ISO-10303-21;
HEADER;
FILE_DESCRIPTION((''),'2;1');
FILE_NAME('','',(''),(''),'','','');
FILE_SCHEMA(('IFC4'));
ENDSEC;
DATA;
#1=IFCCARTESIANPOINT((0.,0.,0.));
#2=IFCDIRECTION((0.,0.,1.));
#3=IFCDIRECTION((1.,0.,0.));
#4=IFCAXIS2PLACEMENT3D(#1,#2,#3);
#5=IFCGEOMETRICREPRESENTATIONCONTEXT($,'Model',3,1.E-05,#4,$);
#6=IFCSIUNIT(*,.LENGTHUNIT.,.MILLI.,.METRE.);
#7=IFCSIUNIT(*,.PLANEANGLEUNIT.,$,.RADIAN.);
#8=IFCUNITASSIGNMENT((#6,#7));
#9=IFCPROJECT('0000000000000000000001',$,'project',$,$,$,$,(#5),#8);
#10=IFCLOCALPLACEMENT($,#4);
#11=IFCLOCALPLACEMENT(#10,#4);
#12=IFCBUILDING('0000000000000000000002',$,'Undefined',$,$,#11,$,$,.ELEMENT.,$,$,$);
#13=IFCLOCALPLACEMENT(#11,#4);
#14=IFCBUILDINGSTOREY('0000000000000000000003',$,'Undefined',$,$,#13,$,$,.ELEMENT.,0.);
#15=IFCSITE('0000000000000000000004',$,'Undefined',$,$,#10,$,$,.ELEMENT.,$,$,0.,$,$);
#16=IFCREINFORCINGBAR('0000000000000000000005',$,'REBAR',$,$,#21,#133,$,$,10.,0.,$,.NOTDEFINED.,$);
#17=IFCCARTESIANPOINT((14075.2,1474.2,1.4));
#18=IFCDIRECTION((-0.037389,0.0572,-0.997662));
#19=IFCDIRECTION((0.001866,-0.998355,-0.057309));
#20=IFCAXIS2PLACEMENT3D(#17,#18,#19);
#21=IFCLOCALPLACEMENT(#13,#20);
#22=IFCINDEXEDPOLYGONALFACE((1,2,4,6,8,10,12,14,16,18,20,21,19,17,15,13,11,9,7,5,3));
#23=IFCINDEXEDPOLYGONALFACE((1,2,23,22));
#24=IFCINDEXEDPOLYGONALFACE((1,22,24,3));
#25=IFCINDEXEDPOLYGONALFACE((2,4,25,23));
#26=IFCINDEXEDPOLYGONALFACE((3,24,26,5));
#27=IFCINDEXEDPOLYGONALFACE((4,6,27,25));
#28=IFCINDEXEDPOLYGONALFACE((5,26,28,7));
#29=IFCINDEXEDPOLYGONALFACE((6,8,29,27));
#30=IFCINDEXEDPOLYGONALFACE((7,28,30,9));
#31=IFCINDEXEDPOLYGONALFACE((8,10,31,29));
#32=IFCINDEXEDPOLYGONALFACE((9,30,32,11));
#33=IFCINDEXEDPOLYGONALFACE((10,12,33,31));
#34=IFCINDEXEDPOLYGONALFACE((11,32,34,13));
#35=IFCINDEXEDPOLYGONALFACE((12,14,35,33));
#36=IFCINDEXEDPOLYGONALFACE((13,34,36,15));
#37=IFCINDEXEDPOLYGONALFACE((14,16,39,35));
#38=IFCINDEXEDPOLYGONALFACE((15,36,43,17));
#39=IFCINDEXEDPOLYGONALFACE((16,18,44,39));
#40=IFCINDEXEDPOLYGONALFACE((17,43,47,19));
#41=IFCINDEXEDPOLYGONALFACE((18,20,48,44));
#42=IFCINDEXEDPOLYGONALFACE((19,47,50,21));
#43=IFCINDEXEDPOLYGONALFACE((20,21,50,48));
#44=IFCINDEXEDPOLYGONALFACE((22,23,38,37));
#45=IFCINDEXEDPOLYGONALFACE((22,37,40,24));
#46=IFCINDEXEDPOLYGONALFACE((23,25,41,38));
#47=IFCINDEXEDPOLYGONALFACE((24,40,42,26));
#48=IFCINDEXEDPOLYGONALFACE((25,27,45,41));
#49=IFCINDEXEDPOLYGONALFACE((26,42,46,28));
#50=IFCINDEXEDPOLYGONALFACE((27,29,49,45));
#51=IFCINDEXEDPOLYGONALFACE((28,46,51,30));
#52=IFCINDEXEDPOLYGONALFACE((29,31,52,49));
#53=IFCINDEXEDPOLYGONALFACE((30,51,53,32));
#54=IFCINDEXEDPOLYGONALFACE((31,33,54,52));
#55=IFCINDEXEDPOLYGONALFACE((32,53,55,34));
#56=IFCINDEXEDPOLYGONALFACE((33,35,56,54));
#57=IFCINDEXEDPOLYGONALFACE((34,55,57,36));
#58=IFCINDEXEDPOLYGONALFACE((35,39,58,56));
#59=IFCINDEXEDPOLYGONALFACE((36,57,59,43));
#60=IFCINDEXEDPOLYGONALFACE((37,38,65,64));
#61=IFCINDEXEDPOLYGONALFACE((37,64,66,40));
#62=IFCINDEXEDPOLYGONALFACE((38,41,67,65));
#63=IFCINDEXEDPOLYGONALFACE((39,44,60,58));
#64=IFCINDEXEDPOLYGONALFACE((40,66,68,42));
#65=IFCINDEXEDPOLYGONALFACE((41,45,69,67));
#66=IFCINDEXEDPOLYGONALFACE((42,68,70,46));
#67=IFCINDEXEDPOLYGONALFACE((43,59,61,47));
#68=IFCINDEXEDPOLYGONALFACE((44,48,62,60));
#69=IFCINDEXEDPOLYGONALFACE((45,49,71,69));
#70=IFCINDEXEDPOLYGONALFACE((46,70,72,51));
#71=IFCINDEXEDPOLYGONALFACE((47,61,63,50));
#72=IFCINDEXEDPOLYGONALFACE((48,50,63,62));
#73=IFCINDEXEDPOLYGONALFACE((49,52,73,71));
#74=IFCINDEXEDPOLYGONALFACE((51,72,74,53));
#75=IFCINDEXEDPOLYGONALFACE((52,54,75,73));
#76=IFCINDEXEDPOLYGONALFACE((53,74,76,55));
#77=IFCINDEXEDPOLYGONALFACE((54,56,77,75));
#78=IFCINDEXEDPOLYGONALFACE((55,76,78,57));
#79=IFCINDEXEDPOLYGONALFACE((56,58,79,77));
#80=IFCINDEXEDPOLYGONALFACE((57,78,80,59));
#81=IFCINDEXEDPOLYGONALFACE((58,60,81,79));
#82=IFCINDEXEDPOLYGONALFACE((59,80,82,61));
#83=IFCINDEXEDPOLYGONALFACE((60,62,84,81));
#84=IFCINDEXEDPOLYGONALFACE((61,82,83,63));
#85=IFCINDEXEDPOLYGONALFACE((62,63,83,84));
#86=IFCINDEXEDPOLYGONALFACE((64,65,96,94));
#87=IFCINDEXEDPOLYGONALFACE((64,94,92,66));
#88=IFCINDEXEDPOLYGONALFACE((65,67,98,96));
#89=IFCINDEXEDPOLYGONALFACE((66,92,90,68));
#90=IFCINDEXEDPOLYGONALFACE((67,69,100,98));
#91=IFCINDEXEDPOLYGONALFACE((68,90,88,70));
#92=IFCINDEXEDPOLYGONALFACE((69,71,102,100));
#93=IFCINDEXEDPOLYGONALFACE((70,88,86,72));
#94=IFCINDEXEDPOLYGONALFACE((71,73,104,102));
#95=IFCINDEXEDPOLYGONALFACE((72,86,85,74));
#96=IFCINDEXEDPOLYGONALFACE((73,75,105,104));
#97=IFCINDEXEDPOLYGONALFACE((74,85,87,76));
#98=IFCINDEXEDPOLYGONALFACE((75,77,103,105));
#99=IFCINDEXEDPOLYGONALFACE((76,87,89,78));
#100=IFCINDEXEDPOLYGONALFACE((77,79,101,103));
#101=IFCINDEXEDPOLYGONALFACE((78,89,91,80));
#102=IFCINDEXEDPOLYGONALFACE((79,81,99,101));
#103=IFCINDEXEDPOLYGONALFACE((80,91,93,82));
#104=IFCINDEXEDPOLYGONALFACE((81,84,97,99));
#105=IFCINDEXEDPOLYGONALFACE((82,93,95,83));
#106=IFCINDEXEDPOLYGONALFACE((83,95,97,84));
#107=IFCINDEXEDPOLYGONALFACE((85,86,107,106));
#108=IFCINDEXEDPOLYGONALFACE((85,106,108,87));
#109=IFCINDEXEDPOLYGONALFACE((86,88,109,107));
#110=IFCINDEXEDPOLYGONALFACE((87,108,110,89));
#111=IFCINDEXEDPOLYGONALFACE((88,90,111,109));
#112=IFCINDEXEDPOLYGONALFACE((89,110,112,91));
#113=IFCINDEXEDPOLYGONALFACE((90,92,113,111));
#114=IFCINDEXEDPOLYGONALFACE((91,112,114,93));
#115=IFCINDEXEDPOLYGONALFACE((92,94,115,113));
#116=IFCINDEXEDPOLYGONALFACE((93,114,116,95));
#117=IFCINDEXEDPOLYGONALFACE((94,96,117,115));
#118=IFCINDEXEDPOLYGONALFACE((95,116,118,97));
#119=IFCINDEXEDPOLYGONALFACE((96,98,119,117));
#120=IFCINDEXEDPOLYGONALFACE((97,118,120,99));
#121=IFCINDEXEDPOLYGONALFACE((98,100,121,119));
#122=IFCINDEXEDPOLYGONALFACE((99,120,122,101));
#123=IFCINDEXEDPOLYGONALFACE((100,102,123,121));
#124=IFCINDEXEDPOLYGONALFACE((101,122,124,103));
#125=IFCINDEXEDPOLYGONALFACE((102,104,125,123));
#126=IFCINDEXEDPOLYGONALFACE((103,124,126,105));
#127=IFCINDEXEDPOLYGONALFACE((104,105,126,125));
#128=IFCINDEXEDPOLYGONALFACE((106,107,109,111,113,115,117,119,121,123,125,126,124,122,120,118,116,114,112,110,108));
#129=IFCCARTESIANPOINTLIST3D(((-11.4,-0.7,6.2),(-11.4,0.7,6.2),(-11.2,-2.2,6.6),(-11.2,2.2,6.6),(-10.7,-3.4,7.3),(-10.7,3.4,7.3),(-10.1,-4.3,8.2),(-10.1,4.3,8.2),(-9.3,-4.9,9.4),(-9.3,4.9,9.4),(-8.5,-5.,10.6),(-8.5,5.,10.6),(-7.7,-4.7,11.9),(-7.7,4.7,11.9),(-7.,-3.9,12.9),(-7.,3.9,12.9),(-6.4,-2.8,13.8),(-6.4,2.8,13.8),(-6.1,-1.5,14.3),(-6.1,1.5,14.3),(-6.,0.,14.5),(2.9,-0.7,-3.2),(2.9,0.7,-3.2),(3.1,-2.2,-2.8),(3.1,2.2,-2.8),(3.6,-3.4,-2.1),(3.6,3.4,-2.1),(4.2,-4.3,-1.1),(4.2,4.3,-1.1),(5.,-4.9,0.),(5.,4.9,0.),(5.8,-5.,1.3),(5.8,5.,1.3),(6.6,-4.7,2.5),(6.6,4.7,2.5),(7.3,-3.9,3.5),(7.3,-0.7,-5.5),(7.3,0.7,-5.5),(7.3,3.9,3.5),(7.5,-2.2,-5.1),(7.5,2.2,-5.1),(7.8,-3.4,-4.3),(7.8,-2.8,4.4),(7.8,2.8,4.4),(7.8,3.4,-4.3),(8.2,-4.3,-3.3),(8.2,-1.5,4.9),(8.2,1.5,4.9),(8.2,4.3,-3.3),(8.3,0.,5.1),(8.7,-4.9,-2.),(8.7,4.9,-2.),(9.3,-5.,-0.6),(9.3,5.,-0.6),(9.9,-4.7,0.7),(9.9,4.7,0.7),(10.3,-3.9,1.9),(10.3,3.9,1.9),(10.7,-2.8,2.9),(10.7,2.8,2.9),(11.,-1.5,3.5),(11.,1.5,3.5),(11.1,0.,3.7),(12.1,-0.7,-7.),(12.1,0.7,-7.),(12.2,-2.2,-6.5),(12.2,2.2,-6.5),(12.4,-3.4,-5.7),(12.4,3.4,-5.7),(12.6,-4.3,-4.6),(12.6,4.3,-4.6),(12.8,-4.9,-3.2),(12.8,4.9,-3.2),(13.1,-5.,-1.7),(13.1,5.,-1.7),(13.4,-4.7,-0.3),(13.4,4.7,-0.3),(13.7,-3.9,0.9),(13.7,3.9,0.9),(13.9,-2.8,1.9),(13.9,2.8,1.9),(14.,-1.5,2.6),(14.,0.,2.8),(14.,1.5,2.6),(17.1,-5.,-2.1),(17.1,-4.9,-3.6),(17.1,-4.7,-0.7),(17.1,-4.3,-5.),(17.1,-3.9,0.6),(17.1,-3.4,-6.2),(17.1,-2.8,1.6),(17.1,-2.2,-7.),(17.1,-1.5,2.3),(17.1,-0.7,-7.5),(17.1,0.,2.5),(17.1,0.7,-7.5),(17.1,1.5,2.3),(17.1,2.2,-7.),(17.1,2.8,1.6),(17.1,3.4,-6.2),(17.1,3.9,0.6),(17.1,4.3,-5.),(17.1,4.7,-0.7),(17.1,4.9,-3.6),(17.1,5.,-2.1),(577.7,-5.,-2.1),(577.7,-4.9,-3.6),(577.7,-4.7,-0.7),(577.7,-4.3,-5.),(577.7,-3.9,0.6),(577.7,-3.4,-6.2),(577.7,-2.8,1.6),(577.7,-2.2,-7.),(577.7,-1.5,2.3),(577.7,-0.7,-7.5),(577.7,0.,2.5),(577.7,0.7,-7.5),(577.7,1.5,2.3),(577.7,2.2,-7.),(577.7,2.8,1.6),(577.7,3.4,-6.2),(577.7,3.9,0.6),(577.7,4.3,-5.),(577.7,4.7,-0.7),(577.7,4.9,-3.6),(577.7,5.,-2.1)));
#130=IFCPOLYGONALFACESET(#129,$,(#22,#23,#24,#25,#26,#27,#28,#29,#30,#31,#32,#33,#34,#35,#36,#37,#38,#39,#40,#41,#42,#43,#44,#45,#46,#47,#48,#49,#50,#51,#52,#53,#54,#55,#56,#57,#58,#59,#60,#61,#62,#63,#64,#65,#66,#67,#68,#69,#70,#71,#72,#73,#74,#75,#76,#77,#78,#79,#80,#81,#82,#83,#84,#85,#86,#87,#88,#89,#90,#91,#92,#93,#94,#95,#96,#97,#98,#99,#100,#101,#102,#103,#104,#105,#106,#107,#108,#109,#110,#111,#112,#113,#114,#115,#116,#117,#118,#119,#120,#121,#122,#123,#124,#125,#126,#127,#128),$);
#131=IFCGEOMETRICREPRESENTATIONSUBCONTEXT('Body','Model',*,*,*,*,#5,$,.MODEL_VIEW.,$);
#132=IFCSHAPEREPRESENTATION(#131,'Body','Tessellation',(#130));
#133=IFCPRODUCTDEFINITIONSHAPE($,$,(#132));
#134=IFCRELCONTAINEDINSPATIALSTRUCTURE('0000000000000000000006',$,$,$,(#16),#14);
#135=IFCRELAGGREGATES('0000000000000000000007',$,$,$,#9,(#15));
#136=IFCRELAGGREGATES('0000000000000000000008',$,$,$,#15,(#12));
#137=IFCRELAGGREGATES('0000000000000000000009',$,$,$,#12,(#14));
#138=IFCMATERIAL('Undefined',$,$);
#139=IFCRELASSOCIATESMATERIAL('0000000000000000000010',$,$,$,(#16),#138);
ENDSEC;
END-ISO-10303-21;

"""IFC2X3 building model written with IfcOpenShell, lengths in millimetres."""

from ifc_helpers import new_model, entity, si_unit, frame, origin_with_axes, place, context, subcontext, project, spatial, source, transform, mapped, material, element, save


model = new_model("IFC2X3")

# Units and contexts
model_context = context("Model", 3, precision=1e-05, world=origin_with_axes())
body_context = subcontext(model_context, "Body", "Model", "MODEL_VIEW")
ifc_project = project(units=[si_unit("LENGTHUNIT", "METRE", prefix="MILLI"), si_unit("PLANEANGLEUNIT", "RADIAN")], contexts=[model_context])

# Site, building, storey
site_placement = place(None, origin_with_axes())
site = spatial("IfcSite", under=ifc_project, at=site_placement, Name="Undefined", CompositionType="ELEMENT", RefElevation=0.0)
building_placement = place(site_placement, origin_with_axes())
building = spatial("IfcBuilding", under=site, at=building_placement, Name="Undefined", CompositionType="ELEMENT")
storey_placement = place(building_placement, origin_with_axes())
storey = spatial("IfcBuildingStorey", under=building, at=storey_placement, Name="Undefined", CompositionType="ELEMENT", Elevation=0.0)

# Reinforcing bar
ifc_material_1 = material(Name="Undefined")
shared_shape_1 = source(origin_with_axes(), body_context, "Body", "AdvancedSweptSolid", [
    entity("IfcSweptDiskSolid", entity("IfcCompositeCurve", [entity("IfcCompositeCurveSegment", "CONTINUOUS", True, entity("IfcTrimmedCurve", entity("IfcLine", entity("IfcCartesianPoint", [0.0, 0.0, 0.0]), entity("IfcVector", entity("IfcDirection", [0.835483, 0.0, -0.549516]), 1.0)), [entity("IfcParameterValue", 0.0)], [entity("IfcParameterValue", 17.082101)], True, "PARAMETER")), entity("IfcCompositeCurveSegment", "CONTINUOUS", True, entity("IfcTrimmedCurve", entity("IfcCircle", entity("IfcAxis2Placement3D", entity("IfcCartesianPoint", [25.8, 0.0, 8.2]), entity("IfcDirection", [0.0, -1.0, 0.0]), entity("IfcDirection", [-0.549516, 0.0, -0.835483])), 21.0), [entity("IfcParameterValue", 0.0)], [entity("IfcParameterValue", 0.581785)], True, "PARAMETER")), entity("IfcCompositeCurveSegment", "DISCONTINUOUS", True, entity("IfcTrimmedCurve", entity("IfcLine", entity("IfcCartesianPoint", [25.8, 0.0, -12.8]), entity("IfcVector", entity("IfcDirection", [1.0, 0.0, 0.0]), 1.0)), [entity("IfcParameterValue", 0.0)], [entity("IfcParameterValue", 560.593055)], True, "PARAMETER"))], False), 5.0, None, 0.0, 578.3),
])
reinforcing_bar_1_placement = place(storey_placement, frame((14075.2, 1474.2, 1.4), z_axis=(-0.037389, 0.0572, -0.997662), x_axis=(0.001866, -0.998355, -0.057309)))
element("IfcReinforcingBar", 1, at=reinforcing_bar_1_placement, inside=storey, material=ifc_material_1, Name="REBAR", BarRole="NOTDEFINED", CrossSectionArea=0.0, NominalDiameter=10.0, context=body_context, shape_type="MappedRepresentation", body=[
    mapped(shared_shape_1, transform((-8.7, 0.0, 10.3))),
])

save(model, "model.ifc")
